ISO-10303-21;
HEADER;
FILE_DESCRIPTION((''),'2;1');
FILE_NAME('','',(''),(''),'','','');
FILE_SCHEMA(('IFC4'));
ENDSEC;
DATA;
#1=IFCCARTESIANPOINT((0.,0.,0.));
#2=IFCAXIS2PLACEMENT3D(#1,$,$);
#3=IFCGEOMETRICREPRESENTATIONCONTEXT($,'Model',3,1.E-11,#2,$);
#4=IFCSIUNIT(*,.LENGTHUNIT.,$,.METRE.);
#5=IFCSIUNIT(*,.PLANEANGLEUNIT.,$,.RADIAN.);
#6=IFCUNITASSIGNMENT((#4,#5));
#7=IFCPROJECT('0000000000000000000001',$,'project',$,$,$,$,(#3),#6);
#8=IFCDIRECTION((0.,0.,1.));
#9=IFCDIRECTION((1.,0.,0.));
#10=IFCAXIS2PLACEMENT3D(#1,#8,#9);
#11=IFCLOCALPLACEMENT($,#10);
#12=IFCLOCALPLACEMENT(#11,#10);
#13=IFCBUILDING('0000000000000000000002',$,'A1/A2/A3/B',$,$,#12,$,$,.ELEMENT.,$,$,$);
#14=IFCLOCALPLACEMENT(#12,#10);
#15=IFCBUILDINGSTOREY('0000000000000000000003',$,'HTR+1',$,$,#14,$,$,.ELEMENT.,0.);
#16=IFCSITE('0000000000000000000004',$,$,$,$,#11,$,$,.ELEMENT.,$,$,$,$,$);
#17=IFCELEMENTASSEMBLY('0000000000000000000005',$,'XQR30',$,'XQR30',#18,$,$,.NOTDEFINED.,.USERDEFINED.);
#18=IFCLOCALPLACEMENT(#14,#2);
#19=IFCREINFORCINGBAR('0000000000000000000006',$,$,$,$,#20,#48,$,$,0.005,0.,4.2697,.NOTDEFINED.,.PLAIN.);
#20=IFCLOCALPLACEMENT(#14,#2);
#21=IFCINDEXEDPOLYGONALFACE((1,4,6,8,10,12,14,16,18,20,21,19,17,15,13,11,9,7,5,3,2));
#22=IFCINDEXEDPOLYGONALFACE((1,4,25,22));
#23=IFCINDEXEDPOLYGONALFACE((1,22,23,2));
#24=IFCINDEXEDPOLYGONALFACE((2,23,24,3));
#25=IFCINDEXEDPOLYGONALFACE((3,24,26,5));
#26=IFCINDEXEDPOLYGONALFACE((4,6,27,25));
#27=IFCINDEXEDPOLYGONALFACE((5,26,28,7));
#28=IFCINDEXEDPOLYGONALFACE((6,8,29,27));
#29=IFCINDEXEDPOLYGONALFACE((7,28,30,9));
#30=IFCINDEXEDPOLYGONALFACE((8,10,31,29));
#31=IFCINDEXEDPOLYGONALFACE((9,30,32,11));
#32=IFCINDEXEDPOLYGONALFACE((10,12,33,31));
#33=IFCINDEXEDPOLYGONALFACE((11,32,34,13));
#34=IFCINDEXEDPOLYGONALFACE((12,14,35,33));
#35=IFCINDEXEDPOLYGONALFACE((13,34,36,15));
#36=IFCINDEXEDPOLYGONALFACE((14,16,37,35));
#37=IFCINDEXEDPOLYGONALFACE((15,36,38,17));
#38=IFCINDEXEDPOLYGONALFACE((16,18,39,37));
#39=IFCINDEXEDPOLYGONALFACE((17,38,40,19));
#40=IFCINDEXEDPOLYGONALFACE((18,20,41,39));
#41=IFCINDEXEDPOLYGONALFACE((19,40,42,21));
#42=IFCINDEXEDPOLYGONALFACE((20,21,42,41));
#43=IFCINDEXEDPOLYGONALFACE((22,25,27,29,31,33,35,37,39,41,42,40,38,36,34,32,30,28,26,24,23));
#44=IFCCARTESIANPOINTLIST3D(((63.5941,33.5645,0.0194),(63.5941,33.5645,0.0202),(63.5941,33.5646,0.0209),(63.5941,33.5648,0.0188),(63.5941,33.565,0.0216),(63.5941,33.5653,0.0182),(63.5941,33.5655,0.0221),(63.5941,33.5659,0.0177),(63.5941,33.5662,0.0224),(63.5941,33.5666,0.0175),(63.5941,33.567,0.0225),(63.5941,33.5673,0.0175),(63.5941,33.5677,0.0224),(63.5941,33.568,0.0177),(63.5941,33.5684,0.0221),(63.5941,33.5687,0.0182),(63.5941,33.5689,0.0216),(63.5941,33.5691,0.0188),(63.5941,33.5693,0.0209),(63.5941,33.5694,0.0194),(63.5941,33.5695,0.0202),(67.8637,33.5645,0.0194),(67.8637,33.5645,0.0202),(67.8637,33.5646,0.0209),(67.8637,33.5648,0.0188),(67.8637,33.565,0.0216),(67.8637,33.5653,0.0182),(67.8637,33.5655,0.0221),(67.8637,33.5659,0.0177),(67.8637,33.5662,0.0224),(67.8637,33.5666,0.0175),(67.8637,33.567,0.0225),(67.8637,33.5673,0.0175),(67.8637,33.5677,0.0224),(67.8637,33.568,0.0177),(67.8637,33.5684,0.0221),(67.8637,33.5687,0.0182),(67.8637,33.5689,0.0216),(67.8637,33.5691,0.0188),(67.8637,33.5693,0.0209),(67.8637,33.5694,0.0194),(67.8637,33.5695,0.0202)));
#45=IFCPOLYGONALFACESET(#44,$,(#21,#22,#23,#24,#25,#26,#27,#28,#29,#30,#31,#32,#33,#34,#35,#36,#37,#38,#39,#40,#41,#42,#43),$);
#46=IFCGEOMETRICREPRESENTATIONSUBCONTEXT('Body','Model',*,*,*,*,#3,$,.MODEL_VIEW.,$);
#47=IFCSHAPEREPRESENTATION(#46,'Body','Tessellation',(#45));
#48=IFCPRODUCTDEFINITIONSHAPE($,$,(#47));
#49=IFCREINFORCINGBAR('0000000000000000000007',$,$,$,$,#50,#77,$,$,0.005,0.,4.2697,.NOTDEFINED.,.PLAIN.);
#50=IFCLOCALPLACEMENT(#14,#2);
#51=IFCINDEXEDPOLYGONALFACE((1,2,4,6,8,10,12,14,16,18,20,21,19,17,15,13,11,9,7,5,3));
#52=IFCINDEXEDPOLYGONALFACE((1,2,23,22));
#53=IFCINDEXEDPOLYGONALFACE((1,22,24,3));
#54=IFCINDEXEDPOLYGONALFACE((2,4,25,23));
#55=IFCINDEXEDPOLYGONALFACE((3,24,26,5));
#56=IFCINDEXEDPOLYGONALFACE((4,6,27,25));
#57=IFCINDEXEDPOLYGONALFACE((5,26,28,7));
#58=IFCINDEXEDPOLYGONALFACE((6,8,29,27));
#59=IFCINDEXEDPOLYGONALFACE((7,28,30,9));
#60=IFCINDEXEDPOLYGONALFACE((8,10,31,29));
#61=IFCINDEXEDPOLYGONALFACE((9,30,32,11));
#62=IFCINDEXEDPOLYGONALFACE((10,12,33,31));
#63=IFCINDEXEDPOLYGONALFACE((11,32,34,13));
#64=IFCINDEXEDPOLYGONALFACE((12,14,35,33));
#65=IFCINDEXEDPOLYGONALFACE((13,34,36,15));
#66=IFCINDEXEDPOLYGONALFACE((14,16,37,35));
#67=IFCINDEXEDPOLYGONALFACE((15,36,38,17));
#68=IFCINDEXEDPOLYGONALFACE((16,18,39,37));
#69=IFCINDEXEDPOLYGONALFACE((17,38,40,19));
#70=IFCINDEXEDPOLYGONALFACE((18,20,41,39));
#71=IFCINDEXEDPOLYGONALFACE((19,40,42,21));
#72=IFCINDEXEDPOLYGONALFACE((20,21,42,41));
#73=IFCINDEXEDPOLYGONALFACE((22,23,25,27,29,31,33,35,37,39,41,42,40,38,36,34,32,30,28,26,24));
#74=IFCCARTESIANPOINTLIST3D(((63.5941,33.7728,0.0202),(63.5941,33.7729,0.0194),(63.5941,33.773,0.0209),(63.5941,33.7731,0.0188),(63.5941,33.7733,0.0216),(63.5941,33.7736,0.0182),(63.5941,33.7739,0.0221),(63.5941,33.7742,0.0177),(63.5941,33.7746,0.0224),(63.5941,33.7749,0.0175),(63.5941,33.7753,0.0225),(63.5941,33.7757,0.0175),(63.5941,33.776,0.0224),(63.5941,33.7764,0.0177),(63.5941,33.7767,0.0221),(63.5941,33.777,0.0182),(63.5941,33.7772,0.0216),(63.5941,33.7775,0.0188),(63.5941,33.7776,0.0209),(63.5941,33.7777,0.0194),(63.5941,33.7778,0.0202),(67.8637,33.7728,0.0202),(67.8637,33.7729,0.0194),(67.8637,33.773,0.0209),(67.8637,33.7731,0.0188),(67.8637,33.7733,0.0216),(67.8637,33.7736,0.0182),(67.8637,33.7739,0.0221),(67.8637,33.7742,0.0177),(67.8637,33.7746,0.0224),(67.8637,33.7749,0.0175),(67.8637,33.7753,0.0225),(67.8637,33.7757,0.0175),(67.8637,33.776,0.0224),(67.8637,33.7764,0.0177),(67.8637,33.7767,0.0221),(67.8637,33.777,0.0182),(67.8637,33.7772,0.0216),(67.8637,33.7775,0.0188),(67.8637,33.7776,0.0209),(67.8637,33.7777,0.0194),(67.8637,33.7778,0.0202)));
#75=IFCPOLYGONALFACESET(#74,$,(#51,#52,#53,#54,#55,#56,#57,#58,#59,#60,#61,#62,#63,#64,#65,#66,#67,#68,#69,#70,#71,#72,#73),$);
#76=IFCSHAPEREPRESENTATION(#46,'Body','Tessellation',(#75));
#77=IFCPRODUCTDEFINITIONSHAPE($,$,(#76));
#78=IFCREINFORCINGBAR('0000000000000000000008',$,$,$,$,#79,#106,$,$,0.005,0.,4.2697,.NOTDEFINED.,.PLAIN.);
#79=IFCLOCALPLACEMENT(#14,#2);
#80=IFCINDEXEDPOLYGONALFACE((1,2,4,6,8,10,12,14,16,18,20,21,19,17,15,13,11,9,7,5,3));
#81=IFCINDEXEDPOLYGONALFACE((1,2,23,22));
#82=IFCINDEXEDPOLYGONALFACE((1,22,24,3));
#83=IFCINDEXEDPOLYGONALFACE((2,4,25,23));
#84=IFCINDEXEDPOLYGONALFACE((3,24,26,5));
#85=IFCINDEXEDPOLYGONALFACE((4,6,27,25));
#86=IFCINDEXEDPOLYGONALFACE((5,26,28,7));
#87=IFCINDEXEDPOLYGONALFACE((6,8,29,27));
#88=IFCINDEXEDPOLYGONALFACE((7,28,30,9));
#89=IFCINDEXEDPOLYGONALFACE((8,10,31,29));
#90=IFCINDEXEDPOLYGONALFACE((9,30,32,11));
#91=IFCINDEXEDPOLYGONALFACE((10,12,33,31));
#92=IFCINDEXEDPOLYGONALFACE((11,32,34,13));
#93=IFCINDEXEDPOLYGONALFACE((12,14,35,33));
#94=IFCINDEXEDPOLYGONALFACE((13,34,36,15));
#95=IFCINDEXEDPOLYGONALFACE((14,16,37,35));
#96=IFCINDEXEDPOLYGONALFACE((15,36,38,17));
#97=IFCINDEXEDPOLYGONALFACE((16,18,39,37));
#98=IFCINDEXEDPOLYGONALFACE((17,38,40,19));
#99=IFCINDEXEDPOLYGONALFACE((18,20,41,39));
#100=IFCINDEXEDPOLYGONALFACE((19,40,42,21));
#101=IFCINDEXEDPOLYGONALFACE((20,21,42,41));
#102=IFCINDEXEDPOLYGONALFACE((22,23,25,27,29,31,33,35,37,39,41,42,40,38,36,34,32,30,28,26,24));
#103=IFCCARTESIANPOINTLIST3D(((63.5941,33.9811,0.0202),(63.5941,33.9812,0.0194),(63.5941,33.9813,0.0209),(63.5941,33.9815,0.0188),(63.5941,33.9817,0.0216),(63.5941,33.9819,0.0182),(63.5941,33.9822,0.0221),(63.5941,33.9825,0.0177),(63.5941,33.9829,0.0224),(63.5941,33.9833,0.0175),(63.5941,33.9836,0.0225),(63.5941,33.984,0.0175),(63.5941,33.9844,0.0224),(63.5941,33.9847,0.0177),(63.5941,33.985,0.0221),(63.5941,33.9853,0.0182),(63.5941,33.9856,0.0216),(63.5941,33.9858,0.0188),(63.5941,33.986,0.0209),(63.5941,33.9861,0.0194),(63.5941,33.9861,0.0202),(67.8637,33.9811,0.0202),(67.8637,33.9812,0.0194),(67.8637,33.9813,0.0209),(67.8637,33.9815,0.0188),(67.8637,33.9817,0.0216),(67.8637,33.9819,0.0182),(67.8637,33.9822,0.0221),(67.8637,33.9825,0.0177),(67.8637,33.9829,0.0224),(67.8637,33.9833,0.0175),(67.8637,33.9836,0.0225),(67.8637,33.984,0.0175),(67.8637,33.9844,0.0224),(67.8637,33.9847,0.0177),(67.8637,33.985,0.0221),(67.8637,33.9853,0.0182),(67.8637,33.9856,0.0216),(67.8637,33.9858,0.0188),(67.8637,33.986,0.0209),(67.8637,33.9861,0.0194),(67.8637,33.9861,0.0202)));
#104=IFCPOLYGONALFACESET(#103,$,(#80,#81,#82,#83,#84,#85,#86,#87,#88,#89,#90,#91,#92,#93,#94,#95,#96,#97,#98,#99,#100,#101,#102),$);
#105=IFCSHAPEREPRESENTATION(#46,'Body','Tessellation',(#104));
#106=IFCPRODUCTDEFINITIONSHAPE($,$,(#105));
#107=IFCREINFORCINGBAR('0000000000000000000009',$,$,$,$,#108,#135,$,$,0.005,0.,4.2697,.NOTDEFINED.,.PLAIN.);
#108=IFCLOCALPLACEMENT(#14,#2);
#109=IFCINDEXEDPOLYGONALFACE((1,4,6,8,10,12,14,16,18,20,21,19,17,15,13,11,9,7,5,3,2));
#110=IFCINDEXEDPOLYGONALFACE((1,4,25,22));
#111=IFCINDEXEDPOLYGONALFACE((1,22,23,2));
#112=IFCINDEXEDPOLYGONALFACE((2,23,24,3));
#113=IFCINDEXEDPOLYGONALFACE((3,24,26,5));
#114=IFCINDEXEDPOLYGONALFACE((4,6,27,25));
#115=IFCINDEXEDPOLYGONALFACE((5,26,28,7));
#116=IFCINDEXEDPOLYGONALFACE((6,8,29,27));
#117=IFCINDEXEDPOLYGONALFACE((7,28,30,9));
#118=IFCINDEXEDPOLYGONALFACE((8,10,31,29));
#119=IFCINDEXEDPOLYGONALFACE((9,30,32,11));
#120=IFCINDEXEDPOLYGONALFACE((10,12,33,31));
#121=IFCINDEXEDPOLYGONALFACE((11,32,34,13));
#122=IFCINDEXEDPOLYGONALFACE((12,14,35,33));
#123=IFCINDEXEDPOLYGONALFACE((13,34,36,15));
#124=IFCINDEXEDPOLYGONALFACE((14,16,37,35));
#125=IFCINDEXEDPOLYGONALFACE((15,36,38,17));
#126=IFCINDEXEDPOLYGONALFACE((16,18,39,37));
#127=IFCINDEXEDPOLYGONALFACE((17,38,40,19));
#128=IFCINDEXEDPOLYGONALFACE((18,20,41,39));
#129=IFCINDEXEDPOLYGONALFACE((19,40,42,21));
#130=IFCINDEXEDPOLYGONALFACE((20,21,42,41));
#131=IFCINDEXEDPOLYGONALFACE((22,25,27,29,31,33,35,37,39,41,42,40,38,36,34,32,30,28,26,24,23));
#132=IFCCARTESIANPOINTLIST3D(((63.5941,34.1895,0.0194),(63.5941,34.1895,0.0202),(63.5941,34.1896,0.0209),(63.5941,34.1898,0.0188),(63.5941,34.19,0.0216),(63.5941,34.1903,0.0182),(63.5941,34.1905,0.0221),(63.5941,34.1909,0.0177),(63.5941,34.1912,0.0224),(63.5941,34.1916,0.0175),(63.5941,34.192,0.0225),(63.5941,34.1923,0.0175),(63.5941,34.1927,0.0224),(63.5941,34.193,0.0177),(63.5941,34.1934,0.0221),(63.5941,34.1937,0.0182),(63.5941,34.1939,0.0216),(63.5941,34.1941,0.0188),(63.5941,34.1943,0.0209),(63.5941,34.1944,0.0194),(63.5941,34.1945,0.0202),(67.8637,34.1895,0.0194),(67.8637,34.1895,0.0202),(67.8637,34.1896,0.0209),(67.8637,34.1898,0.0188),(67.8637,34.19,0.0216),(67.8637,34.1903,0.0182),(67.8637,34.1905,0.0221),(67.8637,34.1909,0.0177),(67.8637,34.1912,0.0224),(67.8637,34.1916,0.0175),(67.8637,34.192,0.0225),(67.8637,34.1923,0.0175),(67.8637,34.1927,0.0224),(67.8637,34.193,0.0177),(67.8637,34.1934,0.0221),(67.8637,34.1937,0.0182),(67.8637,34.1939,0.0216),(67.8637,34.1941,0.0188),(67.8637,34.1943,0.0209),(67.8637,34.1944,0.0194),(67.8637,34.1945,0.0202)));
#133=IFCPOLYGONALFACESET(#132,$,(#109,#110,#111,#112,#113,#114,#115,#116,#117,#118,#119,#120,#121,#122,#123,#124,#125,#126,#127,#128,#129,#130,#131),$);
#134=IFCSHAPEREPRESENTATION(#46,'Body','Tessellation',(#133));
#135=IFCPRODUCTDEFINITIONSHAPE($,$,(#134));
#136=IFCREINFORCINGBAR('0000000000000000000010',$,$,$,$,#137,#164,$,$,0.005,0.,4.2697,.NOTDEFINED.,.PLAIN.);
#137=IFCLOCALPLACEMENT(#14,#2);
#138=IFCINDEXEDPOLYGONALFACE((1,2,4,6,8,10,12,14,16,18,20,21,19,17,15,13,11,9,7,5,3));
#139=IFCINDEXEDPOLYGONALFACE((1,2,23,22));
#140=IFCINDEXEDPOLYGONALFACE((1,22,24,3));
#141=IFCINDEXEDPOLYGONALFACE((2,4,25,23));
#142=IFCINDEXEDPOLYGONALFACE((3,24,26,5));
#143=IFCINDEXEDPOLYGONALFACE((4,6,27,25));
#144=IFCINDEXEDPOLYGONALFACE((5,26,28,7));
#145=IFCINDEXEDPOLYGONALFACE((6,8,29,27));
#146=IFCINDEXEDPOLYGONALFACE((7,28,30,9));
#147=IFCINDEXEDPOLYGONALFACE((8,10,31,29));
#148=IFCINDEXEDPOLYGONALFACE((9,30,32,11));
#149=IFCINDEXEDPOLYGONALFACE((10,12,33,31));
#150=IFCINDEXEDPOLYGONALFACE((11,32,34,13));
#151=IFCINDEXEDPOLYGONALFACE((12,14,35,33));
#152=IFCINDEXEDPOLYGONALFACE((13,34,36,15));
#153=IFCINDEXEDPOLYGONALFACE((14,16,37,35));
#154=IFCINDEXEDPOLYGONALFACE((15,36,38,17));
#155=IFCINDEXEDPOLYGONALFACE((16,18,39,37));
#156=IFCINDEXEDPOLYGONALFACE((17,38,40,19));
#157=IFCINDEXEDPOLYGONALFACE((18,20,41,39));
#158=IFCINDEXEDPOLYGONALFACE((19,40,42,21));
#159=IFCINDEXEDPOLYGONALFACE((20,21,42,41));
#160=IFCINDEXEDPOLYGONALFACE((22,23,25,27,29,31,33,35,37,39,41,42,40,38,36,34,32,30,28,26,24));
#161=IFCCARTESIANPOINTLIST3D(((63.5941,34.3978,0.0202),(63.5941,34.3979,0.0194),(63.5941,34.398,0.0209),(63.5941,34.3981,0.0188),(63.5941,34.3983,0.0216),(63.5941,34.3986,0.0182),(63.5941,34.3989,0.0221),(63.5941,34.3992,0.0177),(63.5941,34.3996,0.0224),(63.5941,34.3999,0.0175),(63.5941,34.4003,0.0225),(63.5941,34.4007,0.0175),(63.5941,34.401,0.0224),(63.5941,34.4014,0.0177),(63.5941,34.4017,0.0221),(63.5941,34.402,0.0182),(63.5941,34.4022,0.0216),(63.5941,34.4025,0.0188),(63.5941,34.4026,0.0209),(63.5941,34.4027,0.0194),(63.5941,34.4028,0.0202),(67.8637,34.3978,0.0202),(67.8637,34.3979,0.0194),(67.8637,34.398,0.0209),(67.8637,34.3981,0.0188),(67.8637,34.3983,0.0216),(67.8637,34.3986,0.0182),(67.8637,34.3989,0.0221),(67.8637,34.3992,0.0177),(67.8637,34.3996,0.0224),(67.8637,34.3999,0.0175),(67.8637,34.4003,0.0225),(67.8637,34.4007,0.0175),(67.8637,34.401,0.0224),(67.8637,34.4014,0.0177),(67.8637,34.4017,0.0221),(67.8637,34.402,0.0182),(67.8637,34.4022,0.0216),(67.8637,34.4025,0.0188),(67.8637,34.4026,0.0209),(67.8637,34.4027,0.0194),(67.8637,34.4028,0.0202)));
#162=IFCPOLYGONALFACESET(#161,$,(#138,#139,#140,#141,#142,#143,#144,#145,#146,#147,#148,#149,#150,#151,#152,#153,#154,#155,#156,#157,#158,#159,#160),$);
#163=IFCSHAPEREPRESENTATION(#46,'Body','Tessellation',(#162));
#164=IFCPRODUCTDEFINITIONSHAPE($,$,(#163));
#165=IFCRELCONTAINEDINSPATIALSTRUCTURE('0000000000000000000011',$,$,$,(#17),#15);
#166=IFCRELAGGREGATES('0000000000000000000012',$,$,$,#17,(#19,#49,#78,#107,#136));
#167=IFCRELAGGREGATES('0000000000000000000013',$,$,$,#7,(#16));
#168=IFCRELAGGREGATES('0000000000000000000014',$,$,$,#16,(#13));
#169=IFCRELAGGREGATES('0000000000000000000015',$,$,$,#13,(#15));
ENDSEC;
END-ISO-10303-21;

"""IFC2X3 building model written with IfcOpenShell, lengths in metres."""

from ifc_helpers import new_model, entity, si_unit, origin, origin_with_axes, place, context, subcontext, project, spatial, shape, element, aggregate, save


model = new_model("IFC2X3")

# Units and contexts
model_context = context("Model", 3, precision=1e-11, world=origin())
body_context = subcontext(model_context, "Body", "Model", "MODEL_VIEW")
ifc_project = project(units=[si_unit("LENGTHUNIT", "METRE"), si_unit("PLANEANGLEUNIT", "RADIAN")], contexts=[model_context])

# Site, building, storey
site_placement = place(None, origin_with_axes())
site = spatial("IfcSite", under=ifc_project, at=site_placement, CompositionType="ELEMENT")
building_placement = place(site_placement, origin_with_axes())
building = spatial("IfcBuilding", under=site, at=building_placement, Name="A1/A2/A3/B", CompositionType="ELEMENT")
storey_placement = place(building_placement, origin_with_axes())
storey = spatial("IfcBuildingStorey", under=building, at=storey_placement, Name="HTR+1", CompositionType="ELEMENT", Elevation=0.0)

# Element assembly, reinforcing bars
assembly_1_placement = place(storey_placement, origin_with_axes())
assembly_1 = element("IfcElementAssembly", 1, at=assembly_1_placement, inside=storey, Name="XQR30", ObjectType="XQR30", AssemblyPlace="NOTDEFINED", PredefinedType="USERDEFINED")
reinforcing_bar_1_placement = place(assembly_1_placement, origin_with_axes())
reinforcing_bar_1 = element("IfcReinforcingBar", 2, at=reinforcing_bar_1_placement, BarLength=4.2697, BarRole="NOTDEFINED", BarSurface="PLAIN", CrossSectionArea=0.0, NominalDiameter=0.005, shapes=[
    shape(body_context, "Body", "AdvancedSweptSolid", [entity("IfcSweptDiskSolid", entity("IfcPolyline", [entity("IfcCartesianPoint", [63.5941, 33.567, 0.02]), entity("IfcCartesianPoint", [67.8637, 33.567, 0.02])]), 0.0025, None, 0.0, 4.2697)]),
    shape(body_context, "Body", "AdvancedSweptSolid", [entity("IfcSweptDiskSolid", entity("IfcPolyline", [entity("IfcCartesianPoint", [63.5941, 33.567, 0.02]), entity("IfcCartesianPoint", [67.8637, 33.567, 0.02])]), 0.0025, None, 0.0, 4.2697)]),
])
reinforcing_bar_2_placement = place(assembly_1_placement, origin_with_axes())
reinforcing_bar_2 = element("IfcReinforcingBar", 3, at=reinforcing_bar_2_placement, BarLength=4.2697, BarRole="NOTDEFINED", BarSurface="PLAIN", CrossSectionArea=0.0, NominalDiameter=0.005, shapes=[
    shape(body_context, "Body", "AdvancedSweptSolid", [entity("IfcSweptDiskSolid", entity("IfcPolyline", [entity("IfcCartesianPoint", [63.5941, 33.7753, 0.02]), entity("IfcCartesianPoint", [67.8637, 33.7753, 0.02])]), 0.0025, None, 0.0, 4.2697)]),
    shape(body_context, "Body", "AdvancedSweptSolid", [entity("IfcSweptDiskSolid", entity("IfcPolyline", [entity("IfcCartesianPoint", [63.5941, 33.7753, 0.02]), entity("IfcCartesianPoint", [67.8637, 33.7753, 0.02])]), 0.0025, None, 0.0, 4.2697)]),
])
reinforcing_bar_3_placement = place(assembly_1_placement, origin_with_axes())
reinforcing_bar_3 = element("IfcReinforcingBar", 4, at=reinforcing_bar_3_placement, BarLength=4.2697, BarRole="NOTDEFINED", BarSurface="PLAIN", CrossSectionArea=0.0, NominalDiameter=0.005, shapes=[
    shape(body_context, "Body", "AdvancedSweptSolid", [entity("IfcSweptDiskSolid", entity("IfcPolyline", [entity("IfcCartesianPoint", [63.5941, 33.9836, 0.02]), entity("IfcCartesianPoint", [67.8637, 33.9836, 0.02])]), 0.0025, None, 0.0, 4.2697)]),
    shape(body_context, "Body", "AdvancedSweptSolid", [entity("IfcSweptDiskSolid", entity("IfcPolyline", [entity("IfcCartesianPoint", [63.5941, 33.9836, 0.02]), entity("IfcCartesianPoint", [67.8637, 33.9836, 0.02])]), 0.0025, None, 0.0, 4.2697)]),
])
reinforcing_bar_4_placement = place(assembly_1_placement, origin_with_axes())
reinforcing_bar_4 = element("IfcReinforcingBar", 5, at=reinforcing_bar_4_placement, BarLength=4.2697, BarRole="NOTDEFINED", BarSurface="PLAIN", CrossSectionArea=0.0, NominalDiameter=0.005, shapes=[
    shape(body_context, "Body", "AdvancedSweptSolid", [entity("IfcSweptDiskSolid", entity("IfcPolyline", [entity("IfcCartesianPoint", [63.5941, 34.192, 0.02]), entity("IfcCartesianPoint", [67.8637, 34.192, 0.02])]), 0.0025, None, 0.0, 4.2697)]),
    shape(body_context, "Body", "AdvancedSweptSolid", [entity("IfcSweptDiskSolid", entity("IfcPolyline", [entity("IfcCartesianPoint", [63.5941, 34.192, 0.02]), entity("IfcCartesianPoint", [67.8637, 34.192, 0.02])]), 0.0025, None, 0.0, 4.2697)]),
])
reinforcing_bar_5_placement = place(assembly_1_placement, origin_with_axes())
reinforcing_bar_5 = element("IfcReinforcingBar", 6, at=reinforcing_bar_5_placement, BarLength=4.2697, BarRole="NOTDEFINED", BarSurface="PLAIN", CrossSectionArea=0.0, NominalDiameter=0.005, shapes=[
    shape(body_context, "Body", "AdvancedSweptSolid", [entity("IfcSweptDiskSolid", entity("IfcPolyline", [entity("IfcCartesianPoint", [63.5941, 34.4003, 0.02]), entity("IfcCartesianPoint", [67.8637, 34.4003, 0.02])]), 0.0025, None, 0.0, 4.2697)]),
    shape(body_context, "Body", "AdvancedSweptSolid", [entity("IfcSweptDiskSolid", entity("IfcPolyline", [entity("IfcCartesianPoint", [63.5941, 34.4003, 0.02]), entity("IfcCartesianPoint", [67.8637, 34.4003, 0.02])]), 0.0025, None, 0.0, 4.2697)]),
])
aggregate(assembly_1, [reinforcing_bar_1, reinforcing_bar_2, reinforcing_bar_3, reinforcing_bar_4, reinforcing_bar_5])

save(model, "model.ifc")
